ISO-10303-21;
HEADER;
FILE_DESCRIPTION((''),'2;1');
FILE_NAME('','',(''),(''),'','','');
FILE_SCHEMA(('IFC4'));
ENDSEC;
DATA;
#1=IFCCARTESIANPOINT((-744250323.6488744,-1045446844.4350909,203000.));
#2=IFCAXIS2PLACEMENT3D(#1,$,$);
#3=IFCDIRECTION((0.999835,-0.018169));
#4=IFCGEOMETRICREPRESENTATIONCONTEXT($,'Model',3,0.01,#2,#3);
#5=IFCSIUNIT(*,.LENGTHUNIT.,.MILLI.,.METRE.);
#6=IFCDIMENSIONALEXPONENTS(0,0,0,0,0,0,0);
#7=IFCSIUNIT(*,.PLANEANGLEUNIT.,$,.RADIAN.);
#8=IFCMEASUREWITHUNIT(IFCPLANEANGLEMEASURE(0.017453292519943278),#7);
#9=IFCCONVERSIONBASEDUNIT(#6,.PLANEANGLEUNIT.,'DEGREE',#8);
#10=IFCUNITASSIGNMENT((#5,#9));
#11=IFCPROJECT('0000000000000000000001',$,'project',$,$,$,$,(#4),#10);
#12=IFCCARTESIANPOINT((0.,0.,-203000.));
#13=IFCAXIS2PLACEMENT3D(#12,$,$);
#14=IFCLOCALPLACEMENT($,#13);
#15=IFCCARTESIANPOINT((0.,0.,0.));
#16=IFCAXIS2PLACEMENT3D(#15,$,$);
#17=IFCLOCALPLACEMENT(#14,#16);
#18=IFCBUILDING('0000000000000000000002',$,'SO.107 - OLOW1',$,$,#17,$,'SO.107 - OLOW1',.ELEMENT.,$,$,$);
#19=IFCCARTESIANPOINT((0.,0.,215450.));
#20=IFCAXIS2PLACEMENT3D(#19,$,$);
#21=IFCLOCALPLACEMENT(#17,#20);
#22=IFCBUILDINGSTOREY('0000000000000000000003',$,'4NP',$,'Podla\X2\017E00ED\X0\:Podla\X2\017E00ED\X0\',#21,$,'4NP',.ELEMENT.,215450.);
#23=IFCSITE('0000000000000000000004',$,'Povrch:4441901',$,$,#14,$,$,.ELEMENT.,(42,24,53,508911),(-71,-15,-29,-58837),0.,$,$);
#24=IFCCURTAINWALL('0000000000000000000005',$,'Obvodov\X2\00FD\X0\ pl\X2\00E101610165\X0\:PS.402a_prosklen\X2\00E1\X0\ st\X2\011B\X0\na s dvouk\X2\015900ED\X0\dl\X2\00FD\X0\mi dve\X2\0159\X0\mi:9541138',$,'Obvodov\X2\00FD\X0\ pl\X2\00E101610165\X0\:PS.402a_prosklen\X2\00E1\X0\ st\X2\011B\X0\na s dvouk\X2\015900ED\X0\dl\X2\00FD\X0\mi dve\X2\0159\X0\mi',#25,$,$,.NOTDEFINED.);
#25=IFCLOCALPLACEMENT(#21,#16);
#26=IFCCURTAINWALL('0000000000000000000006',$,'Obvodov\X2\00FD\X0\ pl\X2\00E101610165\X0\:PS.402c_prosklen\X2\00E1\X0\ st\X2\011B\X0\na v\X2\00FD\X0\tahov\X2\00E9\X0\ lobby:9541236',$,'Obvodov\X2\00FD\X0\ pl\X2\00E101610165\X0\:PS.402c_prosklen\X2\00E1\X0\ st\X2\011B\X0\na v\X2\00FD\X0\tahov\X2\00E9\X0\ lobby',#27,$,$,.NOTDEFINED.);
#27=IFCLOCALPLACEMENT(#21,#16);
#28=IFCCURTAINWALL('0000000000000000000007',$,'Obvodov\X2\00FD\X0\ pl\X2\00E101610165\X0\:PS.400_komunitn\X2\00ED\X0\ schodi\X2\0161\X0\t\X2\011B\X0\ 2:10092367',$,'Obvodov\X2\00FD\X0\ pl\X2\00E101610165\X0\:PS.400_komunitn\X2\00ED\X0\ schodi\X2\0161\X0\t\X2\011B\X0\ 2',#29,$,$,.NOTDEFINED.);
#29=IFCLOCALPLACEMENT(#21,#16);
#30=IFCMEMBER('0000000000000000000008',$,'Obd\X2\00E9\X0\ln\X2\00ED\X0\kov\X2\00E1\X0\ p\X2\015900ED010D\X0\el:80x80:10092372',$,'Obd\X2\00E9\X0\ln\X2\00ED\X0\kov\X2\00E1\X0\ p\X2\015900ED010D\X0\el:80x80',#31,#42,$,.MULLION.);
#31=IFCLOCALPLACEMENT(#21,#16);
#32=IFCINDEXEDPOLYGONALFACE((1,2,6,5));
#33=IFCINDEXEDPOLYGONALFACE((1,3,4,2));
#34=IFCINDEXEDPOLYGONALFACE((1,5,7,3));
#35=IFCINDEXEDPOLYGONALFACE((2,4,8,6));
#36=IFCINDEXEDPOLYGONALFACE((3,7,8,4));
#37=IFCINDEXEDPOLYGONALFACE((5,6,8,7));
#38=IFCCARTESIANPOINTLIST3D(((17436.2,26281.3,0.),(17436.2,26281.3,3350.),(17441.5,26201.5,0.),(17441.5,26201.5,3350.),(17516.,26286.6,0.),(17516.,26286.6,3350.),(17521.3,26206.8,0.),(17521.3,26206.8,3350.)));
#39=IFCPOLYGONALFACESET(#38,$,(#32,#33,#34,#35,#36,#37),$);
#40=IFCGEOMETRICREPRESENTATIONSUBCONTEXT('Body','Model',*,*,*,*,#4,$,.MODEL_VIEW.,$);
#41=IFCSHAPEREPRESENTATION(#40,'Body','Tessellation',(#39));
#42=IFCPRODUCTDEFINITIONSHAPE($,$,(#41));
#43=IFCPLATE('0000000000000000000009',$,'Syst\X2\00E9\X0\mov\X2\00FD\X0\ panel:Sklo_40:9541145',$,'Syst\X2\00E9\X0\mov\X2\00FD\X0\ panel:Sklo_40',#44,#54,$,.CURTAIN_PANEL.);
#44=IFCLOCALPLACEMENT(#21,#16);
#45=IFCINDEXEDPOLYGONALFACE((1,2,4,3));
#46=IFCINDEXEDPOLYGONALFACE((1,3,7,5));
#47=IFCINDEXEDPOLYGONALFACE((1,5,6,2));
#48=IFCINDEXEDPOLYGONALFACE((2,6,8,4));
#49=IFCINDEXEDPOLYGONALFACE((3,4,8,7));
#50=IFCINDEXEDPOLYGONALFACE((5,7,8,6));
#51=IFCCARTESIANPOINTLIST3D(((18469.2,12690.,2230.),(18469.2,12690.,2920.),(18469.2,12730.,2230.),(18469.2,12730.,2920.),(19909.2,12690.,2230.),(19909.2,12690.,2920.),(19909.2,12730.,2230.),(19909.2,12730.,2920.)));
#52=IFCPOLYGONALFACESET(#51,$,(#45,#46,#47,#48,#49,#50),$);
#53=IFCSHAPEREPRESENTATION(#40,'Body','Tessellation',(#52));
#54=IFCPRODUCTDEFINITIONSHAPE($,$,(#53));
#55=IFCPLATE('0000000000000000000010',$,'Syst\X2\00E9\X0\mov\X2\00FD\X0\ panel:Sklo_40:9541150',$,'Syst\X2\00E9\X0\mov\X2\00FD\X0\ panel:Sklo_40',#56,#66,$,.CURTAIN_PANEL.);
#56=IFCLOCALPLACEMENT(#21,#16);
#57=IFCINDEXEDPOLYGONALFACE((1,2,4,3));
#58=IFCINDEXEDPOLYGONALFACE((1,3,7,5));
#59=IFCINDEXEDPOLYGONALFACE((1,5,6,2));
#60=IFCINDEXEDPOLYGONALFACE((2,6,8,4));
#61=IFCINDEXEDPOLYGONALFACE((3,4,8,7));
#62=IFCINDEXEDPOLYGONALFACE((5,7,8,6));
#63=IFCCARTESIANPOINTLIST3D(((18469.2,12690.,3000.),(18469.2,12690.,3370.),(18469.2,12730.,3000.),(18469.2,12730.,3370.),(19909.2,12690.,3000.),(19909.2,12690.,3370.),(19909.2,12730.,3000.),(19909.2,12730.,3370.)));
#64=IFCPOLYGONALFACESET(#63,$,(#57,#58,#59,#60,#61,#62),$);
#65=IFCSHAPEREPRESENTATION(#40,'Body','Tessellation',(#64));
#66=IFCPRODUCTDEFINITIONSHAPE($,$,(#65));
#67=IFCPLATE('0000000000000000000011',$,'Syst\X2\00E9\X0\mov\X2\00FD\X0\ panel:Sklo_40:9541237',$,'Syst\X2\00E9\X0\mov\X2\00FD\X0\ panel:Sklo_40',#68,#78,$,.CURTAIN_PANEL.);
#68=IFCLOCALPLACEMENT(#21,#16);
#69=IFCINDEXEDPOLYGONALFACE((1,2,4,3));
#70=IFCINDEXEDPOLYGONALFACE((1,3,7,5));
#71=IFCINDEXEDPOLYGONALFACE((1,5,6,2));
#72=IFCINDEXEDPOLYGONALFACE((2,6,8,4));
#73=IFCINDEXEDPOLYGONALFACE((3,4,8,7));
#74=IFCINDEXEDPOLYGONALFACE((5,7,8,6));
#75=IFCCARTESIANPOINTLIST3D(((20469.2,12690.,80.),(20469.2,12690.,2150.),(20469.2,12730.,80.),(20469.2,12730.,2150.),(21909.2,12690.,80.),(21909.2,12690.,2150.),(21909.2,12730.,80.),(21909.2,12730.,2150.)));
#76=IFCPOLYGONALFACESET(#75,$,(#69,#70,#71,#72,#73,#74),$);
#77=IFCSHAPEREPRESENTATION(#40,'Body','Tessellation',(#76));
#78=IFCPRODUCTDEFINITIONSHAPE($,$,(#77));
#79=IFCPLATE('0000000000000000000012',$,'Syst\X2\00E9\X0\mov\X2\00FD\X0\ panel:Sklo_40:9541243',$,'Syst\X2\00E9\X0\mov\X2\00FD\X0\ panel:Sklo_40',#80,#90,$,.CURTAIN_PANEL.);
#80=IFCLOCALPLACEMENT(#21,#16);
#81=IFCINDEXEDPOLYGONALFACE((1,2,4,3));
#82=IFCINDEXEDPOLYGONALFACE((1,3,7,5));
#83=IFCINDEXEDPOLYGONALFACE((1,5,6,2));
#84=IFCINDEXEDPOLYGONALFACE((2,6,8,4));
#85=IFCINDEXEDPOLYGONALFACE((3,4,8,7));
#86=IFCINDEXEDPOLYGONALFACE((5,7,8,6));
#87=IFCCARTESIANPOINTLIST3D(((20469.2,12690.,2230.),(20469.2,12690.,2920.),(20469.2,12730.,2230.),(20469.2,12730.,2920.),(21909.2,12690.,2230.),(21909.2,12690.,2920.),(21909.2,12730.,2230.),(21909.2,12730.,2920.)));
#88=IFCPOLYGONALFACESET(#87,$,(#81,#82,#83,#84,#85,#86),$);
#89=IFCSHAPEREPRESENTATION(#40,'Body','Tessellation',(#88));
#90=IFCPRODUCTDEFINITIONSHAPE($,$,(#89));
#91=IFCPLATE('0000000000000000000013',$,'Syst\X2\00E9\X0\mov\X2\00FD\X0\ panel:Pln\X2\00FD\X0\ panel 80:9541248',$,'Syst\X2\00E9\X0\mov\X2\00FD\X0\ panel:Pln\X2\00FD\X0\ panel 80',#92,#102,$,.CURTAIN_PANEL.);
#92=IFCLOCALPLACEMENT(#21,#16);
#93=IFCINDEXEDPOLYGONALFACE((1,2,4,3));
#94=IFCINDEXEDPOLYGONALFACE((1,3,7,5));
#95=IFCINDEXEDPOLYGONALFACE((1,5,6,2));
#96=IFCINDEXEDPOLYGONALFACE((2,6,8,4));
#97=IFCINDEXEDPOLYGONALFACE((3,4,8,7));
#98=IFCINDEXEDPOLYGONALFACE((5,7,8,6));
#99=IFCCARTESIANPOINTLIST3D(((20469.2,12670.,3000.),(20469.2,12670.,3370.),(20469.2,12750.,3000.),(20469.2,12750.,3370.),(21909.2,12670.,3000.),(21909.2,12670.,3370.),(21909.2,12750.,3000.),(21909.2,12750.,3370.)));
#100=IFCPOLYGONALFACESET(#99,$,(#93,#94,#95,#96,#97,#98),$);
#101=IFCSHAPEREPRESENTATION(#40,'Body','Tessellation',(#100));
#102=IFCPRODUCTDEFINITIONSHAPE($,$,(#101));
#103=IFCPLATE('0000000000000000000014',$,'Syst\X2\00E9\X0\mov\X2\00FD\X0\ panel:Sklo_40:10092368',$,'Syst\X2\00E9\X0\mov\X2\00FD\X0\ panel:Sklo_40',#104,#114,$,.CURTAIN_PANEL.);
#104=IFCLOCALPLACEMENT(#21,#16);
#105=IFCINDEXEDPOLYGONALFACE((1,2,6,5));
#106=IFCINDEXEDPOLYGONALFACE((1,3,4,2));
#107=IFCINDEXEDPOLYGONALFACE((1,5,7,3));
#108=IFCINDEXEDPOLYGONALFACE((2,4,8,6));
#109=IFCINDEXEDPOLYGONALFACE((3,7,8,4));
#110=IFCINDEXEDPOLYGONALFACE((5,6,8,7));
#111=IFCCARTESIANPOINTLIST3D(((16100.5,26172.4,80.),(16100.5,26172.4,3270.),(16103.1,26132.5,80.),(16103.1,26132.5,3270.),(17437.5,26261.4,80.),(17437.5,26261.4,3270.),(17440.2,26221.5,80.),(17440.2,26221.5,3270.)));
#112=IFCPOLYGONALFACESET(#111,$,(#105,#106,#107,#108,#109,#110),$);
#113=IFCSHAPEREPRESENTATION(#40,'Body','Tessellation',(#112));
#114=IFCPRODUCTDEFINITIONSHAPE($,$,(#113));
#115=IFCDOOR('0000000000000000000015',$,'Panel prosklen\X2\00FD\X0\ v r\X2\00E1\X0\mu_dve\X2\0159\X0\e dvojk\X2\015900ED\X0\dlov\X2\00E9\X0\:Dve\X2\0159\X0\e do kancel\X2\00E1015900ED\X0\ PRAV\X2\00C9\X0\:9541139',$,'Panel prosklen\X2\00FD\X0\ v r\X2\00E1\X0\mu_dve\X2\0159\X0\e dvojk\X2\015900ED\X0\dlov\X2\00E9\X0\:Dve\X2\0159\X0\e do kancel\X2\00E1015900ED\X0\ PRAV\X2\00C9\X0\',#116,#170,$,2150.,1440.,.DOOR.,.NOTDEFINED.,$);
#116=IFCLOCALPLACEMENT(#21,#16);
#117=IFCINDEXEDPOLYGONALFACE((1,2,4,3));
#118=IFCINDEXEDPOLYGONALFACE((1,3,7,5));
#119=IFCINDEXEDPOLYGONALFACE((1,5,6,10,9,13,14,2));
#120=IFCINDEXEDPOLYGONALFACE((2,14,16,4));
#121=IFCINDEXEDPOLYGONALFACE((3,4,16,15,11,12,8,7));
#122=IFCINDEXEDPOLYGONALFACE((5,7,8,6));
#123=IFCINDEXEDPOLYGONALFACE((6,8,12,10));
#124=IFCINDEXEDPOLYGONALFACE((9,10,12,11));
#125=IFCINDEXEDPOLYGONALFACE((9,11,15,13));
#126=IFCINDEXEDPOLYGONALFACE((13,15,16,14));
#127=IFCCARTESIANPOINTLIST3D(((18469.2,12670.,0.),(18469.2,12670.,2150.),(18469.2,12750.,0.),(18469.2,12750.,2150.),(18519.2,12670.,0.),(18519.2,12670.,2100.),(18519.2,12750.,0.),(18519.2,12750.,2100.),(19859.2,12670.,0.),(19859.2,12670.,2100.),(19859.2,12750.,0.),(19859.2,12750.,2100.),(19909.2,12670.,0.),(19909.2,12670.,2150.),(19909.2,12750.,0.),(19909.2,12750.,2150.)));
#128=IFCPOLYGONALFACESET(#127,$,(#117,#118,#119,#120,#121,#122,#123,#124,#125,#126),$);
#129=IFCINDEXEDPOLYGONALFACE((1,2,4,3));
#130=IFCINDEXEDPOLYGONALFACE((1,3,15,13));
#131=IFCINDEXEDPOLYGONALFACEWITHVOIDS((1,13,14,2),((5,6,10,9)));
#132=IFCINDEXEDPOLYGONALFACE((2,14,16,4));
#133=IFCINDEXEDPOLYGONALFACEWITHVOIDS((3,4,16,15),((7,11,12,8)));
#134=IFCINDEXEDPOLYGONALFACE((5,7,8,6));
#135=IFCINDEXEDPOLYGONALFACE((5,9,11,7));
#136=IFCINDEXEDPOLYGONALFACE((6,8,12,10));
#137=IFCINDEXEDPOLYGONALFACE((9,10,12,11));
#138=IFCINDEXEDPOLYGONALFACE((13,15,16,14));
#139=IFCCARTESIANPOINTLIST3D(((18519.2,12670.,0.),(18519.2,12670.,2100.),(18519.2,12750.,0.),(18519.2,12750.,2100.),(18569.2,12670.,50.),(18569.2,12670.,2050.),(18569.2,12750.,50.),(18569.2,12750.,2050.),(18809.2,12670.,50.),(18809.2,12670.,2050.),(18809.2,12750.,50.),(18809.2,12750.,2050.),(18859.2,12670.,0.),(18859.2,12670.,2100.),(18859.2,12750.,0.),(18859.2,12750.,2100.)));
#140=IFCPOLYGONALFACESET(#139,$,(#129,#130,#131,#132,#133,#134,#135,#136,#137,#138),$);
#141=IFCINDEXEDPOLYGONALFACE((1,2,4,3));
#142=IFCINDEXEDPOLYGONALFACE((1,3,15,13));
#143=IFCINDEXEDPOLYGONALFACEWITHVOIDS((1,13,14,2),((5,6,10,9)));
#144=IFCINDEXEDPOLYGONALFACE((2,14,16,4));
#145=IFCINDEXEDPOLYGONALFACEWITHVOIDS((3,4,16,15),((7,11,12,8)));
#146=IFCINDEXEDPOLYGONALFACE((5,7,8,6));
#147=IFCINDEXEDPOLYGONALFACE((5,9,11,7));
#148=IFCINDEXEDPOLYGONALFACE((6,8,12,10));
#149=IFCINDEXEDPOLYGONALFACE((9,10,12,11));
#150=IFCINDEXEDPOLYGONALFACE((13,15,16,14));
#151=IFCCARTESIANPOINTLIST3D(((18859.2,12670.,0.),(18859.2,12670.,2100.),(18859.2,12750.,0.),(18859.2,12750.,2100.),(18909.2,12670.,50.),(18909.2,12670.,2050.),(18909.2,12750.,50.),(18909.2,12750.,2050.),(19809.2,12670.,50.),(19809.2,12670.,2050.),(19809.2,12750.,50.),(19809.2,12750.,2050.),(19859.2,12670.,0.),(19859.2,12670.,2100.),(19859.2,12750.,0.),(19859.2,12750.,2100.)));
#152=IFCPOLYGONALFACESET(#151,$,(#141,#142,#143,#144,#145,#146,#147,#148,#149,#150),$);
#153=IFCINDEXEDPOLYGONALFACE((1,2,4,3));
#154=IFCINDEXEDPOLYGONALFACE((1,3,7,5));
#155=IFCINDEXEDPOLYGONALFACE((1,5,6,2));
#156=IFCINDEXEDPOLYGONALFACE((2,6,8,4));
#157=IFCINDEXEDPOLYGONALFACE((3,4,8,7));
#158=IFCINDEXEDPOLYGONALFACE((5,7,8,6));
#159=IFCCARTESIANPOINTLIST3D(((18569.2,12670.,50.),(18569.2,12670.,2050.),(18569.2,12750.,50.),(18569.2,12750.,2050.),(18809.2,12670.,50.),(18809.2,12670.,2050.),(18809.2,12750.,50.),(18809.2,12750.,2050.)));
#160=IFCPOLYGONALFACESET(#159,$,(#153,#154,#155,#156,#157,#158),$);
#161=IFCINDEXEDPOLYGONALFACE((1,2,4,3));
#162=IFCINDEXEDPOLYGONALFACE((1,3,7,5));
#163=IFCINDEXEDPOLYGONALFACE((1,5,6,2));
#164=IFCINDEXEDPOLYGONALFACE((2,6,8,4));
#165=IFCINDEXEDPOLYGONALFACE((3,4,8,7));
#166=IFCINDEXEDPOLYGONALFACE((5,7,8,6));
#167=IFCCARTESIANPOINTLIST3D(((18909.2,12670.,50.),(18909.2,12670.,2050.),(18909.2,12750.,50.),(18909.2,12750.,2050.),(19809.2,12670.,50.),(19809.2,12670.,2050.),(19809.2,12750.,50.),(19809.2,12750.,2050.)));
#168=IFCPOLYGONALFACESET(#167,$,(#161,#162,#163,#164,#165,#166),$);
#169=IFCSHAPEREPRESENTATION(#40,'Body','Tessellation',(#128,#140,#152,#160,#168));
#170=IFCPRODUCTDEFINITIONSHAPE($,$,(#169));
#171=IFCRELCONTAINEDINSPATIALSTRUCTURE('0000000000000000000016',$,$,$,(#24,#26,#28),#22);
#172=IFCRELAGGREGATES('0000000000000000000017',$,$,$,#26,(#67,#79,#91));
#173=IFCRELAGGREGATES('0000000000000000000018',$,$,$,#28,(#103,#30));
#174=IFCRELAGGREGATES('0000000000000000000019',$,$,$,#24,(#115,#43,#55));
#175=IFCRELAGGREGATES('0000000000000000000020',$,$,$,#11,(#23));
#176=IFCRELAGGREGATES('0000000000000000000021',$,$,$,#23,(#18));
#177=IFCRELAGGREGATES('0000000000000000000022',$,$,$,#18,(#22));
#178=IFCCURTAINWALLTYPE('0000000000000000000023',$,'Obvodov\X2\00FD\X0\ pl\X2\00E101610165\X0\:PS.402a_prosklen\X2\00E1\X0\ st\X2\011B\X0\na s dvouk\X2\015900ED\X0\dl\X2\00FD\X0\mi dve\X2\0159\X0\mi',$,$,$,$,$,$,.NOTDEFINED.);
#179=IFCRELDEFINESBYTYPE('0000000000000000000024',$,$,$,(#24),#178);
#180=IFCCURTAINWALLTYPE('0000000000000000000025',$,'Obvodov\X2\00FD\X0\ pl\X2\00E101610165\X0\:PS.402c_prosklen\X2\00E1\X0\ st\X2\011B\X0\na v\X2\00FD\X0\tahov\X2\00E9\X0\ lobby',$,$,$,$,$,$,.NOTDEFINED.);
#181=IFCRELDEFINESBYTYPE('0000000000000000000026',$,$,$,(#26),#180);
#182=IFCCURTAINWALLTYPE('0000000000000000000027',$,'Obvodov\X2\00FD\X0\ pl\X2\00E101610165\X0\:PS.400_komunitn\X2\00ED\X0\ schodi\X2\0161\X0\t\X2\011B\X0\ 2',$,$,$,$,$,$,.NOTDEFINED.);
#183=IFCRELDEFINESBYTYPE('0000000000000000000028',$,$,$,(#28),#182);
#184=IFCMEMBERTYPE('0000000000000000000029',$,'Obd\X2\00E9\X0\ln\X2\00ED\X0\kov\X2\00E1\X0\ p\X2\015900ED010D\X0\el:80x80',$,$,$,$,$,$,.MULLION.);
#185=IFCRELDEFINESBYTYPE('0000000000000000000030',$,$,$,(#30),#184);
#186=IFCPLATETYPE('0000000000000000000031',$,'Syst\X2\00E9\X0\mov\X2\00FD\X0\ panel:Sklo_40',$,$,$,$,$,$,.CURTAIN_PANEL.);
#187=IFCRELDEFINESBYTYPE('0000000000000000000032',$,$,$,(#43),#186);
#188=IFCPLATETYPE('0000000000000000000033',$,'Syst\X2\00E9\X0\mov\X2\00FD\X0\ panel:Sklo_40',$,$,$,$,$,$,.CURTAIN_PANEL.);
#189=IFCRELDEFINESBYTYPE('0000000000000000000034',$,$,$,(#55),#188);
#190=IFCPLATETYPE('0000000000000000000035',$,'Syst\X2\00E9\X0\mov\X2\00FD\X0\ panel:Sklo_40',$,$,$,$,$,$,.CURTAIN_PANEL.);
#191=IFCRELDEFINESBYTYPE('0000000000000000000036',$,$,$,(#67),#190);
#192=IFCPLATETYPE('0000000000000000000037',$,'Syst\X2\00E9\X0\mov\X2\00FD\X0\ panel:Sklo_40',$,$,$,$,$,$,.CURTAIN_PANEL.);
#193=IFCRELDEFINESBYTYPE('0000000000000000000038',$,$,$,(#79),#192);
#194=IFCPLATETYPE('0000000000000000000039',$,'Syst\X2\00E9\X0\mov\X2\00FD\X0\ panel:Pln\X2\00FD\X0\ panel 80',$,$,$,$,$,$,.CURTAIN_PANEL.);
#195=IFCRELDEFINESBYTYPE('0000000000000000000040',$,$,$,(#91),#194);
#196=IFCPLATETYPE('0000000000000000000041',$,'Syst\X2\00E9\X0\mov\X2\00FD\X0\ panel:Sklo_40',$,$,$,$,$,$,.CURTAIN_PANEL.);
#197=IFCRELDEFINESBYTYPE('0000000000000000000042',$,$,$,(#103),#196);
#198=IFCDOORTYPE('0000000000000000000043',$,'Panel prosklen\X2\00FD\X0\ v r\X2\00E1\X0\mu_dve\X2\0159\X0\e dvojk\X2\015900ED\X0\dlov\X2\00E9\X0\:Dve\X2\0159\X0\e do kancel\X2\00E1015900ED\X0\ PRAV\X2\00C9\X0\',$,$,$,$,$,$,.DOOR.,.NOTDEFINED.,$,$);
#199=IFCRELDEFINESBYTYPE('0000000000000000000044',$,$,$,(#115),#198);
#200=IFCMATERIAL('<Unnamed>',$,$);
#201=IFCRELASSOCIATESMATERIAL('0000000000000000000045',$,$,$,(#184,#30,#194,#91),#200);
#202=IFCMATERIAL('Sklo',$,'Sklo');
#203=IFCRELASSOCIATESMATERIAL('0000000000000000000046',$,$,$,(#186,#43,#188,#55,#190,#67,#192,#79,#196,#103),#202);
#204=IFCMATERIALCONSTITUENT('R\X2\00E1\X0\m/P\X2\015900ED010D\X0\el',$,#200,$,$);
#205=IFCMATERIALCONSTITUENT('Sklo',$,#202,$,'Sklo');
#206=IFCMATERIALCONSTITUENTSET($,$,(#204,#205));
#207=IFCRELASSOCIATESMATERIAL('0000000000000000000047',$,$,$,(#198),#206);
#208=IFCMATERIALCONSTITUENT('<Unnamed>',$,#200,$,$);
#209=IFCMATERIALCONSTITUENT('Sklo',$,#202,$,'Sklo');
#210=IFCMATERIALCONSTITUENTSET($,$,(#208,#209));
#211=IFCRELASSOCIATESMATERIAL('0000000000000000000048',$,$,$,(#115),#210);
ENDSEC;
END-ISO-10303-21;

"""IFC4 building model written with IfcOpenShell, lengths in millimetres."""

from ifc_helpers import new_model, entity, si_unit, converted_unit, direction, frame, origin, place, context, subcontext, project, spatial, indexed_curve, outline, extrude, source, transform, mapped, material, constituent, constituent_set, type_object, type_shapes, element, aggregate, save


model = new_model("IFC4")

# Units and contexts
model_context = context("Model", 3, precision=0.01, world=frame((-744250323.6488744, -1045446844.4350909, 203000.0)), true_north=direction((0.999835, -0.018169)))
body_context = subcontext(model_context, "Body", "Model", "MODEL_VIEW")
ifc_project = project(units=[si_unit("LENGTHUNIT", "METRE", prefix="MILLI"), converted_unit("PLANEANGLEUNIT", "DEGREE", entity("IfcPlaneAngleMeasure", 0.017453292519943278), si_unit("PLANEANGLEUNIT", "RADIAN"), dimensions=[0, 0, 0, 0, 0, 0, 0])], contexts=[model_context])

# Site, building, storey
site_placement = place(None, frame((0.0, 0.0, -203000.0)))
site = spatial("IfcSite", under=ifc_project, at=site_placement, Name="Povrch:4441901", CompositionType="ELEMENT", RefLatitude=(42, 24, 53, 508911), RefLongitude=(-71, -15, -29, -58837), RefElevation=0.0)
building_placement = place(site_placement, origin())
building = spatial("IfcBuilding", under=site, at=building_placement, Name="SO.107 - OLOW1", LongName="SO.107 - OLOW1", CompositionType="ELEMENT")
storey_placement = place(building_placement, frame((0.0, 0.0, 215450.0)))
storey = spatial("IfcBuildingStorey", under=building, at=storey_placement, Name="4NP", ObjectType="Podlaží:Podlaží", LongName="4NP", CompositionType="ELEMENT", Elevation=215450.0)

# Curtain walls
curtain_wall_type_1 = type_object("IfcCurtainWallType", Name="Obvodový plášť:PS.402a_prosklená stěna s dvoukřídlými dveřmi", PredefinedType="NOTDEFINED")
curtain_wall_1_placement = place(storey_placement, frame((0.0, 0.0, -215450.0)))
curtain_wall_1 = element("IfcCurtainWall", 1, at=curtain_wall_1_placement, inside=storey, type_object=curtain_wall_type_1, Name="Obvodový plášť:PS.402a_prosklená stěna s dvoukřídlými dveřmi:9541138", ObjectType="Obvodový plášť:PS.402a_prosklená stěna s dvoukřídlými dveřmi", PredefinedType="NOTDEFINED")
ifc_material_1 = material(Name="<Unnamed>")
curtain_wall_type_2 = type_object("IfcCurtainWallType", Name="Obvodový plášť:PS.402c_prosklená stěna výtahové lobby", PredefinedType="NOTDEFINED")
curtain_wall_2_placement = place(storey_placement, frame((0.0, 0.0, -215450.0)))
curtain_wall_2 = element("IfcCurtainWall", 2, at=curtain_wall_2_placement, inside=storey, type_object=curtain_wall_type_2, Name="Obvodový plášť:PS.402c_prosklená stěna výtahové lobby:9541236", ObjectType="Obvodový plášť:PS.402c_prosklená stěna výtahové lobby", PredefinedType="NOTDEFINED")

# Curtain wall, member
curtain_wall_type_3 = type_object("IfcCurtainWallType", Name="Obvodový plášť:PS.400_komunitní schodiště 2", PredefinedType="NOTDEFINED")
curtain_wall_3_placement = place(storey_placement, frame((0.0, 0.0, -215450.0)))
curtain_wall_3 = element("IfcCurtainWall", 3, at=curtain_wall_3_placement, inside=storey, type_object=curtain_wall_type_3, Name="Obvodový plášť:PS.400_komunitní schodiště 2:10092367", ObjectType="Obvodový plášť:PS.400_komunitní schodiště 2", PredefinedType="NOTDEFINED")
member_type_1 = type_object("IfcMemberType", Name="Obdélníková příčel:80x80", PredefinedType="MULLION", material=ifc_material_1)
shared_shape_1 = source(origin(), body_context, "Body", "SweptSolid", [
    extrude(outline(indexed_curve([(-40.0, -40.0), (40.0, -40.0), (40.0, 40.0), (-40.0, 40.0), (-40.0, -40.0)], self_intersect=False)), frame((-40.0, 0.0, -3350.0), z_axis=(0.0, 0.0, 1.0), x_axis=(-1.0, 0.0, 0.0)), (0.0, 0.0, 1.0), 3350.0),
])
type_shapes(member_type_1, [shared_shape_1])
member_1_placement = place(curtain_wall_3_placement, frame((17518.6, 26246.7, 218800.0), z_axis=(0.0, 0.0, 1.0), x_axis=(0.997792, 0.066409, 0.0)))
member_1 = element("IfcMember", 4, at=member_1_placement, type_object=member_type_1, material=ifc_material_1, Name="Obdélníková příčel:80x80:10092372", ObjectType="Obdélníková příčel:80x80", PredefinedType="MULLION", context=body_context, shape_type="MappedRepresentation", body=[
    mapped(shared_shape_1, transform((0.0, 0.0, 0.0), scale=1.0)),
])

# Plates
ifc_material_2 = material(Name="Sklo", Category="Sklo")
plate_type_1 = type_object("IfcPlateType", Name="Systémový panel:Sklo_40", PredefinedType="CURTAIN_PANEL", material=ifc_material_2)
shared_shape_2 = source(origin(), body_context, "Body", "SweptSolid", [
    extrude(outline(indexed_curve([(-20.0, -720.0), (20.0, -720.0), (20.0, 720.0), (-20.0, 720.0), (-20.0, -720.0)], self_intersect=False)), frame((0.0, 0.0, 0.0), z_axis=(0.0, 0.0, 1.0), x_axis=(0.0, 1.0, 0.0)), (0.0, 0.0, 1.0), 690.0),
])
type_shapes(plate_type_1, [shared_shape_2])
plate_1_placement = place(curtain_wall_1_placement, frame((19189.2, 12710.0, 217680.0)))
plate_1 = element("IfcPlate", 5, at=plate_1_placement, type_object=plate_type_1, material=ifc_material_2, Name="Systémový panel:Sklo_40:9541145", ObjectType="Systémový panel:Sklo_40", PredefinedType="CURTAIN_PANEL", context=body_context, shape_type="MappedRepresentation", body=[
    mapped(shared_shape_2, transform((0.0, 0.0, 0.0), scale=1.0)),
])
plate_type_2 = type_object("IfcPlateType", Name="Systémový panel:Sklo_40", PredefinedType="CURTAIN_PANEL", material=ifc_material_2)
shared_shape_3 = source(origin(), body_context, "Body", "SweptSolid", [
    extrude(outline(indexed_curve([(-20.0, -720.0), (20.0, -720.0), (20.0, 720.0), (-20.0, 720.0), (-20.0, -720.0)], self_intersect=False)), frame((0.0, 0.0, 0.0), z_axis=(0.0, 0.0, 1.0), x_axis=(0.0, 1.0, 0.0)), (0.0, 0.0, 1.0), 370.0),
])
type_shapes(plate_type_2, [shared_shape_3])
plate_2_placement = place(curtain_wall_1_placement, frame((19189.2, 12710.0, 218450.0)))
plate_2 = element("IfcPlate", 6, at=plate_2_placement, type_object=plate_type_2, material=ifc_material_2, Name="Systémový panel:Sklo_40:9541150", ObjectType="Systémový panel:Sklo_40", PredefinedType="CURTAIN_PANEL", context=body_context, shape_type="MappedRepresentation", body=[
    mapped(shared_shape_3, transform((0.0, 0.0, 0.0), scale=1.0)),
])
plate_type_3 = type_object("IfcPlateType", Name="Systémový panel:Sklo_40", PredefinedType="CURTAIN_PANEL", material=ifc_material_2)
shared_shape_4 = source(origin(), body_context, "Body", "SweptSolid", [
    extrude(outline(indexed_curve([(-20.0, -720.0), (20.0, -720.0), (20.0, 720.0), (-20.0, 720.0), (-20.0, -720.0)], self_intersect=False)), frame((0.0, 0.0, 0.0), z_axis=(0.0, 0.0, 1.0), x_axis=(0.0, 1.0, 0.0)), (0.0, 0.0, 1.0), 2070.0),
])
type_shapes(plate_type_3, [shared_shape_4])
plate_3_placement = place(curtain_wall_2_placement, frame((21189.2, 12710.0, 215530.0)))
plate_3 = element("IfcPlate", 7, at=plate_3_placement, type_object=plate_type_3, material=ifc_material_2, Name="Systémový panel:Sklo_40:9541237", ObjectType="Systémový panel:Sklo_40", PredefinedType="CURTAIN_PANEL", context=body_context, shape_type="MappedRepresentation", body=[
    mapped(shared_shape_4, transform((0.0, 0.0, 0.0), scale=1.0)),
])
plate_type_4 = type_object("IfcPlateType", Name="Systémový panel:Sklo_40", PredefinedType="CURTAIN_PANEL", material=ifc_material_2)
shared_shape_5 = source(origin(), body_context, "Body", "SweptSolid", [
    extrude(outline(indexed_curve([(-20.0, -720.0), (20.0, -720.0), (20.0, 720.0), (-20.0, 720.0), (-20.0, -720.0)], self_intersect=False)), frame((0.0, 0.0, 0.0), z_axis=(0.0, 0.0, 1.0), x_axis=(0.0, 1.0, 0.0)), (0.0, 0.0, 1.0), 690.0),
])
type_shapes(plate_type_4, [shared_shape_5])
plate_4_placement = place(curtain_wall_2_placement, frame((21189.2, 12710.0, 217680.0)))
plate_4 = element("IfcPlate", 8, at=plate_4_placement, type_object=plate_type_4, material=ifc_material_2, Name="Systémový panel:Sklo_40:9541243", ObjectType="Systémový panel:Sklo_40", PredefinedType="CURTAIN_PANEL", context=body_context, shape_type="MappedRepresentation", body=[
    mapped(shared_shape_5, transform((0.0, 0.0, 0.0), scale=1.0)),
])
plate_type_5 = type_object("IfcPlateType", Name="Systémový panel:Plný panel 80", PredefinedType="CURTAIN_PANEL", material=ifc_material_1)
shared_shape_6 = source(origin(), body_context, "Body", "SweptSolid", [
    extrude(outline(indexed_curve([(-40.0, -720.0), (40.0, -720.0), (40.0, 720.0), (-40.0, 720.0), (-40.0, -720.0)], self_intersect=False)), frame((0.0, 0.0, 0.0), z_axis=(0.0, 0.0, 1.0), x_axis=(0.0, 1.0, 0.0)), (0.0, 0.0, 1.0), 370.0),
])
type_shapes(plate_type_5, [shared_shape_6])
plate_5_placement = place(curtain_wall_2_placement, frame((21189.2, 12710.0, 218450.0)))
plate_5 = element("IfcPlate", 9, at=plate_5_placement, type_object=plate_type_5, material=ifc_material_1, Name="Systémový panel:Plný panel 80:9541248", ObjectType="Systémový panel:Plný panel 80", PredefinedType="CURTAIN_PANEL", context=body_context, shape_type="MappedRepresentation", body=[
    mapped(shared_shape_6, transform((0.0, 0.0, 0.0), scale=1.0)),
])
aggregate(curtain_wall_2, [plate_3, plate_4, plate_5])
plate_type_6 = type_object("IfcPlateType", Name="Systémový panel:Sklo_40", PredefinedType="CURTAIN_PANEL", material=ifc_material_2)
shared_shape_7 = source(origin(), body_context, "Body", "SweptSolid", [
    extrude(outline(indexed_curve([(-20.0, -670.0), (20.0, -670.0), (20.0, 670.0), (-20.0, 670.0), (-20.0, -670.0)], self_intersect=False)), frame((0.0, 0.0, 0.0), z_axis=(0.0, 0.0, 1.0), x_axis=(0.0, 1.0, 0.0)), (0.0, 0.0, 1.0), 3190.0),
])
type_shapes(plate_type_6, [shared_shape_7])
plate_6_placement = place(curtain_wall_3_placement, frame((16770.3, 26196.9, 215530.0), z_axis=(0.0, 0.0, 1.0), x_axis=(-0.997792, -0.066409, 0.0)))
plate_6 = element("IfcPlate", 10, at=plate_6_placement, type_object=plate_type_6, material=ifc_material_2, Name="Systémový panel:Sklo_40:10092368", ObjectType="Systémový panel:Sklo_40", PredefinedType="CURTAIN_PANEL", context=body_context, shape_type="MappedRepresentation", body=[
    mapped(shared_shape_7, transform((0.0, 0.0, 0.0), scale=1.0)),
])
aggregate(curtain_wall_3, [plate_6, member_1])

# Door
ifc_constituent_1 = constituent(ifc_material_1, Name="<Unnamed>")
ifc_constituent_2 = constituent(ifc_material_2, Name="Sklo", Category="Sklo")
ifc_constituent_set_1 = constituent_set(constituents=[ifc_constituent_1, ifc_constituent_2])
ifc_constituent_3 = constituent(ifc_material_1, Name="Rám/Příčel")
ifc_constituent_4 = constituent(ifc_material_2, Name="Sklo", Category="Sklo")
ifc_constituent_set_2 = constituent_set(constituents=[ifc_constituent_3, ifc_constituent_4])
door_type = type_object("IfcDoorType", Name="Panel prosklený v rámu_dveře dvojkřídlové:Dveře do kanceláří PRAVÉ", OperationType="NOTDEFINED", PredefinedType="DOOR", material=ifc_constituent_set_2)
shared_shape_8 = source(origin(), body_context, "Body", "SweptSolid", [
    extrude(outline(indexed_curve([(-720.0, -1087.5), (720.0, -1087.5), (720.0, 1062.5), (670.0, 1062.5), (670.0, -1037.5), (-670.0, -1037.5), (-670.0, 1062.5), (-720.0, 1062.5), (-720.0, -1087.5)], self_intersect=False)), frame((0.0, 40.0, 1062.5), z_axis=(0.0, -1.0, 0.0), x_axis=(-1.0, 0.0, 0.0)), (0.0, 0.0, 1.0), 80.0),
    extrude(outline(indexed_curve([(-1050.0, -170.0), (1050.0, -170.0), (1050.0, 170.0), (-1050.0, 170.0), (-1050.0, -170.0)], self_intersect=False), holes=[indexed_curve([(-1000.0, -120.0), (-1000.0, 120.0), (1000.0, 120.0), (1000.0, -120.0), (-1000.0, -120.0)], self_intersect=False)]), frame((-500.0, 40.0, 1050.0), z_axis=(0.0, -1.0, 0.0), x_axis=(0.0, 0.0, -1.0)), (0.0, 0.0, 1.0), 80.0),
    extrude(outline(indexed_curve([(-1050.0, -500.0), (1050.0, -500.0), (1050.0, 500.0), (-1050.0, 500.0), (-1050.0, -500.0)], self_intersect=False), holes=[indexed_curve([(-1000.0, -450.0), (-1000.0, 450.0), (1000.0, 450.0), (1000.0, -450.0), (-1000.0, -450.0)], self_intersect=False)]), frame((170.0, 40.0, 1050.0), z_axis=(0.0, -1.0, 0.0), x_axis=(0.0, 0.0, -1.0)), (0.0, 0.0, 1.0), 80.0),
    extrude(outline(indexed_curve([(-120.0, -40.0), (120.0, -40.0), (120.0, 40.0), (-120.0, 40.0), (-120.0, -40.0)], self_intersect=False)), frame((-500.0, 0.0, 50.0)), (0.0, 0.0, 1.0), 2000.0),
    extrude(outline(indexed_curve([(-450.0, -40.0), (450.0, -40.0), (450.0, 40.0), (-450.0, 40.0), (-450.0, -40.0)], self_intersect=False)), frame((170.0, 0.0, 50.0)), (0.0, 0.0, 1.0), 2000.0),
])
type_shapes(door_type, [shared_shape_8])
door_placement = place(curtain_wall_1_placement, frame((19189.2, 12710.0, 215450.0)))
door = element("IfcDoor", 11, at=door_placement, type_object=door_type, material=ifc_constituent_set_1, Name="Panel prosklený v rámu_dveře dvojkřídlové:Dveře do kanceláří PRAVÉ:9541139", ObjectType="Panel prosklený v rámu_dveře dvojkřídlové:Dveře do kanceláří PRAVÉ", OperationType="NOTDEFINED", OverallHeight=2150.0, OverallWidth=1440.0, PredefinedType="DOOR", context=body_context, shape_type="MappedRepresentation", body=[
    mapped(shared_shape_8, transform((0.0, 0.0, 0.0), scale=1.0)),
])
aggregate(curtain_wall_1, [door, plate_1, plate_2])

save(model, "model.ifc")
